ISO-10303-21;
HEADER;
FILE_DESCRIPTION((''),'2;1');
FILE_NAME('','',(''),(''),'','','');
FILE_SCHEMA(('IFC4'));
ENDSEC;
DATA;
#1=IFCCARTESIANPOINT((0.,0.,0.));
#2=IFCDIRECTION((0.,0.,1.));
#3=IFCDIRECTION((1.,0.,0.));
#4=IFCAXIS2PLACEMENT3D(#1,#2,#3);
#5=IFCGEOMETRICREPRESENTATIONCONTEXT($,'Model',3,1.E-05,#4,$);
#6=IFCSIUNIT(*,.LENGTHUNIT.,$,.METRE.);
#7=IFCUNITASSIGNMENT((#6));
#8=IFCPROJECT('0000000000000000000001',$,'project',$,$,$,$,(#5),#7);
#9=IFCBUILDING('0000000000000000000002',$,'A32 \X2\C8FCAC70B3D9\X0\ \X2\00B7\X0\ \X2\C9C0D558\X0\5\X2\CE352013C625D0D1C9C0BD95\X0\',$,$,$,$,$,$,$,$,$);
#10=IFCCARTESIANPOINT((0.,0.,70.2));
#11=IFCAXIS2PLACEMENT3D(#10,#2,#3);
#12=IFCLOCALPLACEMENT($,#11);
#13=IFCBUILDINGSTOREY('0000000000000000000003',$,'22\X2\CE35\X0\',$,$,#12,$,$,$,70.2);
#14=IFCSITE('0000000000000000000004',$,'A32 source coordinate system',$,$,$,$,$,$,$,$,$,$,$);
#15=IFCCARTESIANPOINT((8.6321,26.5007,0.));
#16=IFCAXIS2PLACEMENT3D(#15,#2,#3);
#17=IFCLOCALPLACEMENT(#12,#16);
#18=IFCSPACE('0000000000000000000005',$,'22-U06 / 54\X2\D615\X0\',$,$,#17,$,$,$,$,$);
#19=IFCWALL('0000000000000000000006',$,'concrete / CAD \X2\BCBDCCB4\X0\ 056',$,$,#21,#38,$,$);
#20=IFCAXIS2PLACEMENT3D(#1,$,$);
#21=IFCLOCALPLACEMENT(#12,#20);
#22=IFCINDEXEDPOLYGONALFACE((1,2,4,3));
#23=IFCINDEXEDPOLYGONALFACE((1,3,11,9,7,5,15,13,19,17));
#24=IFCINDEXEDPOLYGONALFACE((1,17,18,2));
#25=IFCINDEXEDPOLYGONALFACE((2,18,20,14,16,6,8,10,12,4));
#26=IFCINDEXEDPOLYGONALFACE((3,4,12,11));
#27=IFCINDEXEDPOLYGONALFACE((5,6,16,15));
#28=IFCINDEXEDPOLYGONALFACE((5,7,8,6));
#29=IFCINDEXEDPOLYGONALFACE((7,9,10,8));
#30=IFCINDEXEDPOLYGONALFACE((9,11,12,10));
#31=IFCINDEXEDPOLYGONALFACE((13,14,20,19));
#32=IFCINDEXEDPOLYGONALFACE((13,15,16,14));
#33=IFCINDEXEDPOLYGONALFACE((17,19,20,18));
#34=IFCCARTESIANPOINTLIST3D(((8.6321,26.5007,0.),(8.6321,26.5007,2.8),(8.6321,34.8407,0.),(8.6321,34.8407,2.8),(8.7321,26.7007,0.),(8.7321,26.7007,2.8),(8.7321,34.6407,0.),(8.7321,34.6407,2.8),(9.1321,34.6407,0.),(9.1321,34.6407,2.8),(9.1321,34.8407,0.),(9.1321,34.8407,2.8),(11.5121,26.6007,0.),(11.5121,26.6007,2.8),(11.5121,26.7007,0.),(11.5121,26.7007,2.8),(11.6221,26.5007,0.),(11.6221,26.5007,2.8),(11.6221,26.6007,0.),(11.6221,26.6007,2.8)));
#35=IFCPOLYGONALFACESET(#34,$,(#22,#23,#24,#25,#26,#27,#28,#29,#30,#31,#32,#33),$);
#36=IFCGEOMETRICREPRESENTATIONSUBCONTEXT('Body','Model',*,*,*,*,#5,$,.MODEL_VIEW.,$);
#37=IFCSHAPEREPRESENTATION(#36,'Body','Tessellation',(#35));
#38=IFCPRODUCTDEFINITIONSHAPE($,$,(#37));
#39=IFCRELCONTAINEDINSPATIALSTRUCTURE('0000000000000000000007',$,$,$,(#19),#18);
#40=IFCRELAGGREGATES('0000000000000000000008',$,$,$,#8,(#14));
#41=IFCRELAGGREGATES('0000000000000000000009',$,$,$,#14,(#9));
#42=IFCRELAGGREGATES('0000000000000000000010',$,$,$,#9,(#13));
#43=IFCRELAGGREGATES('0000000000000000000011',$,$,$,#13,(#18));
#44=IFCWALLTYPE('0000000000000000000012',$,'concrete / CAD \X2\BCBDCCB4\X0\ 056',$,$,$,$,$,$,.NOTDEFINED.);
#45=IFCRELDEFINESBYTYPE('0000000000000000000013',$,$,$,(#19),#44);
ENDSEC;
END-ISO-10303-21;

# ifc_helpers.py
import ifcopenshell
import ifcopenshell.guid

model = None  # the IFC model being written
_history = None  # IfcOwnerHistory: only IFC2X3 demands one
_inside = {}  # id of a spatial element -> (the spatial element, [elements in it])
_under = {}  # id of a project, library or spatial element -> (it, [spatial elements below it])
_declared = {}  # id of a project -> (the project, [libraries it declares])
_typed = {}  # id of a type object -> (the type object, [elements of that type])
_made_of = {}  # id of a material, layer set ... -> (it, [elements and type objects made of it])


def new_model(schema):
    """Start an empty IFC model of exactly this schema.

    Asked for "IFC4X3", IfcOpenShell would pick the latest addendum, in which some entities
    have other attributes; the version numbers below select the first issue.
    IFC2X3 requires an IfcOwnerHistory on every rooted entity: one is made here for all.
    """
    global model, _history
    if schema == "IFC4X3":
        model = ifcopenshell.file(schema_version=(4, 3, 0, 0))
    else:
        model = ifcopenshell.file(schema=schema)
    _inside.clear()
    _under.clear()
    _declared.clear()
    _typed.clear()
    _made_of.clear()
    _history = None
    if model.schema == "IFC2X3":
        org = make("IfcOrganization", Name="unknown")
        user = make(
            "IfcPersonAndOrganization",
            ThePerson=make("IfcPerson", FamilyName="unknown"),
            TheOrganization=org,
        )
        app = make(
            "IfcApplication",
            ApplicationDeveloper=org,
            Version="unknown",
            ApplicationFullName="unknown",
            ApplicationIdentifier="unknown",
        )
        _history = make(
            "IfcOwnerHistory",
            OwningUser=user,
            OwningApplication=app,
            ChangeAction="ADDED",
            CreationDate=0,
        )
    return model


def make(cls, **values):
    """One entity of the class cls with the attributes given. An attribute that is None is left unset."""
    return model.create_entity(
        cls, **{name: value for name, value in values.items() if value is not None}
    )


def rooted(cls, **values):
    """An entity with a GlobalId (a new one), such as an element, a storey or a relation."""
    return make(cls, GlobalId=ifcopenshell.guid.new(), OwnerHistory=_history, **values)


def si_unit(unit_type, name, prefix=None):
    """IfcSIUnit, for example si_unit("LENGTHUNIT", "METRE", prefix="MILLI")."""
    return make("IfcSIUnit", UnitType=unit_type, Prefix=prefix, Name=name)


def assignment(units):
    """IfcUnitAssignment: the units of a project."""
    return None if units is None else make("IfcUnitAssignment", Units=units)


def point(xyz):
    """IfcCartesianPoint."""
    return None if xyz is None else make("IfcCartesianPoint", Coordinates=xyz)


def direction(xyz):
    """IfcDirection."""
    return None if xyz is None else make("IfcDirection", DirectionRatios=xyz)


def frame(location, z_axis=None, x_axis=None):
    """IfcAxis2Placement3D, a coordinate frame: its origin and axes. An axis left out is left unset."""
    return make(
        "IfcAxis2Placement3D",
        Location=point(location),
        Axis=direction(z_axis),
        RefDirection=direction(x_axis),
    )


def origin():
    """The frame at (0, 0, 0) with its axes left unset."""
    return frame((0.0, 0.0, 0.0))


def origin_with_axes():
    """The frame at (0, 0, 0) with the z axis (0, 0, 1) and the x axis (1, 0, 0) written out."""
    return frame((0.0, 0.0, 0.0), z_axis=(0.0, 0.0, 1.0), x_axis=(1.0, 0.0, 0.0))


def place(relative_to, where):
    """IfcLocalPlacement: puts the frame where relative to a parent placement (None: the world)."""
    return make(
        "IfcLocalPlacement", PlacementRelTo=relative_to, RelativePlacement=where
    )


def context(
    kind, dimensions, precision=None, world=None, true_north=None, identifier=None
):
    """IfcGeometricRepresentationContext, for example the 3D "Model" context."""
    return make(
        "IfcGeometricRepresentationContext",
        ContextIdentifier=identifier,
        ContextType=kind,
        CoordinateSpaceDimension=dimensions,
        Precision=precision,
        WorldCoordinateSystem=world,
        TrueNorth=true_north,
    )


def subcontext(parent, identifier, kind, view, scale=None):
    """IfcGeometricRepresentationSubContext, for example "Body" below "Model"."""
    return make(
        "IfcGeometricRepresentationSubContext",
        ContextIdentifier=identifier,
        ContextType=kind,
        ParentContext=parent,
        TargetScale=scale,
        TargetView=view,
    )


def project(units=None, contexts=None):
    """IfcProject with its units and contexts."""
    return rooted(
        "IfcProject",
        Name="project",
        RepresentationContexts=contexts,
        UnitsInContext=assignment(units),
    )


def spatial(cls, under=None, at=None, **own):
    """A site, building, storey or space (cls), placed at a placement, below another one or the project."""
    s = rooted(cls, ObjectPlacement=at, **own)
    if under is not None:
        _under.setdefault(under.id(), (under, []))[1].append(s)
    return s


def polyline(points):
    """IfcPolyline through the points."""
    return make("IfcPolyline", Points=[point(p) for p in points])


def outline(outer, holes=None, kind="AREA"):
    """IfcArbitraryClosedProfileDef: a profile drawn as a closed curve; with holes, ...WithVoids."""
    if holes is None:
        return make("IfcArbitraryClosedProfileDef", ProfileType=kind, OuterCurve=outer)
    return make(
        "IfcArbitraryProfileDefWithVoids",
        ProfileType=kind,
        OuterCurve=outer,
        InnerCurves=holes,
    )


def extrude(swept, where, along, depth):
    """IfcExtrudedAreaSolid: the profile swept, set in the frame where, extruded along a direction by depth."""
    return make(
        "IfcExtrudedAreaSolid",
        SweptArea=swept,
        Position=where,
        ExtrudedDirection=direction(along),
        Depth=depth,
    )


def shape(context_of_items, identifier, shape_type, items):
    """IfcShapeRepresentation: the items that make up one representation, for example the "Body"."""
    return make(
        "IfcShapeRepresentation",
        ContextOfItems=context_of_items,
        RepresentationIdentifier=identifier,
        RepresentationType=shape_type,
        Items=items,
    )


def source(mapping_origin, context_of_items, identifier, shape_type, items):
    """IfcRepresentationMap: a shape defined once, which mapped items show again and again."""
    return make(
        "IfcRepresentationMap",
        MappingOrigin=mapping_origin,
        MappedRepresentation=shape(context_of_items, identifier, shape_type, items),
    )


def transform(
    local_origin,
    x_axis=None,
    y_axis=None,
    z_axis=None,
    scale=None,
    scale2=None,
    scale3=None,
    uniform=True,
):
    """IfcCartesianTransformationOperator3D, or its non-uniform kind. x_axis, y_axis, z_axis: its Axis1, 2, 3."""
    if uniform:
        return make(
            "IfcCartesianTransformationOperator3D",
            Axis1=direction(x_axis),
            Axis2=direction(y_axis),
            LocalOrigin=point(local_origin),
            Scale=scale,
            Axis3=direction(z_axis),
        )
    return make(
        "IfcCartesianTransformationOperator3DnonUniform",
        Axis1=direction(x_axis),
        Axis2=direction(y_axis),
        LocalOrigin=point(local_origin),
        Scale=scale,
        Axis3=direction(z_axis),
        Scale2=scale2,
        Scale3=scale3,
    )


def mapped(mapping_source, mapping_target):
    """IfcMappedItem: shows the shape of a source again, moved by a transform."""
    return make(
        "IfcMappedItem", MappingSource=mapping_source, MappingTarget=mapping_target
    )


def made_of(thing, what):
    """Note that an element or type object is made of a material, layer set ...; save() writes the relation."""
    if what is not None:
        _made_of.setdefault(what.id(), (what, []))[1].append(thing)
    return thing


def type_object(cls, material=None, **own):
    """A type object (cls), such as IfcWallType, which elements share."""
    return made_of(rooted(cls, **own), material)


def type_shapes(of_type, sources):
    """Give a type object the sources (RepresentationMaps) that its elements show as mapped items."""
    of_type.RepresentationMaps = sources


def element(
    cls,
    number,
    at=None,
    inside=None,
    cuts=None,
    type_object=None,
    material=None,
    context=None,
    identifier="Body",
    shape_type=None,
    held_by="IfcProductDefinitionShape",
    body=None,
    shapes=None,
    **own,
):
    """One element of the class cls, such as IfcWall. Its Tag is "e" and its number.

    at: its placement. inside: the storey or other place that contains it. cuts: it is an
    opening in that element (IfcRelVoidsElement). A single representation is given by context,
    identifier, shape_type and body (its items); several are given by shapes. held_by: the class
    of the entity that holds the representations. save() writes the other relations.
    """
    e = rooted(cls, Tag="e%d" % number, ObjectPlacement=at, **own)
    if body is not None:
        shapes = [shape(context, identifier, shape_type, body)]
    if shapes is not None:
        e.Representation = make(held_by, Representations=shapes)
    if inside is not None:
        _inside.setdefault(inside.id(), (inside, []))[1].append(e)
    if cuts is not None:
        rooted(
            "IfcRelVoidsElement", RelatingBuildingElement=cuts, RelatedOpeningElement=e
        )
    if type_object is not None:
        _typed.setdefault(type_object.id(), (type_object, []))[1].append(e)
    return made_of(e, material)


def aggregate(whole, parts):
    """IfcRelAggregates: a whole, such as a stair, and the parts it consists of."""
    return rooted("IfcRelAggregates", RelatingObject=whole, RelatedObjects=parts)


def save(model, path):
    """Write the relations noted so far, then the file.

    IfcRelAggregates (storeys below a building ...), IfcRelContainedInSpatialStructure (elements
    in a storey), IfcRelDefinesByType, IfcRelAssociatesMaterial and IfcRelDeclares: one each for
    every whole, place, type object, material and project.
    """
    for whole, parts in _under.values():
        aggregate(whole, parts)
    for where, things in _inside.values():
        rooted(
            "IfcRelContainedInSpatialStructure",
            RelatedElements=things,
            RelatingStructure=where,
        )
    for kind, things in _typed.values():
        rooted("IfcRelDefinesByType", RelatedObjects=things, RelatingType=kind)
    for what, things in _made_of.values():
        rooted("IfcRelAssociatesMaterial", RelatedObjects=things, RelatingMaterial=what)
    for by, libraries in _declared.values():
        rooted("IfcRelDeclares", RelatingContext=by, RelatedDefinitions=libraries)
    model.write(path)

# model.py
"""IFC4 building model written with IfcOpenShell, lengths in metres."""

from ifc_helpers import new_model, si_unit, frame, origin, origin_with_axes, place, context, subcontext, project, spatial, polyline, outline, extrude, source, transform, mapped, type_object, type_shapes, element, save


model = new_model("IFC4")

# Units and contexts
model_context = context("Model", 3, precision=1e-05, world=origin_with_axes())
body_context = subcontext(model_context, "Body", "Model", "MODEL_VIEW")
ifc_project = project(units=[si_unit("LENGTHUNIT", "METRE")], contexts=[model_context])

# Site, building, storey, space
site = spatial("IfcSite", under=ifc_project, Name="A32 source coordinate system")
building = spatial("IfcBuilding", under=site, Name="A32 주거동 · 지하5층–옥탑지붕")
storey_placement = place(None, frame((0.0, 0.0, 70.2), z_axis=(0.0, 0.0, 1.0), x_axis=(1.0, 0.0, 0.0)))
storey = spatial("IfcBuildingStorey", under=building, at=storey_placement, Name="22층", Elevation=70.2)
space_placement = place(storey_placement, frame((8.6321, 26.5007, 0.0), z_axis=(0.0, 0.0, 1.0), x_axis=(1.0, 0.0, 0.0)))
space = spatial("IfcSpace", under=storey, at=space_placement, Name="22-U06 / 54형")

# Wall
wall_type_1 = type_object("IfcWallType", Name="concrete / CAD 벽체 056", PredefinedType="NOTDEFINED")
shared_shape_1 = source(origin(), body_context, "Body", "SweptSolid", [
    extrude(outline(polyline([(0.1, 8.14), (0.1, 0.2), (2.88, 0.2), (2.88, 0.1), (2.99, 0.1), (2.99, 0.0), (0.0, 0.0), (0.0, 8.34), (-0.35, 8.34), (-0.35, 8.34), (0.5, 8.34), (0.5, 8.14), (0.1, 8.14)])), origin(), (0.0, 0.0, 1.0), 2.8),
])
type_shapes(wall_type_1, [shared_shape_1])
wall_1_placement = place(space_placement, origin_with_axes())
element("IfcWall", 1, at=wall_1_placement, inside=space, type_object=wall_type_1, Name="concrete / CAD 벽체 056", context=body_context, shape_type="MappedRepresentation", body=[
    mapped(shared_shape_1, transform((0.0, 0.0, 0.0), scale=1.0)),
])

save(model, "model.ifc")
